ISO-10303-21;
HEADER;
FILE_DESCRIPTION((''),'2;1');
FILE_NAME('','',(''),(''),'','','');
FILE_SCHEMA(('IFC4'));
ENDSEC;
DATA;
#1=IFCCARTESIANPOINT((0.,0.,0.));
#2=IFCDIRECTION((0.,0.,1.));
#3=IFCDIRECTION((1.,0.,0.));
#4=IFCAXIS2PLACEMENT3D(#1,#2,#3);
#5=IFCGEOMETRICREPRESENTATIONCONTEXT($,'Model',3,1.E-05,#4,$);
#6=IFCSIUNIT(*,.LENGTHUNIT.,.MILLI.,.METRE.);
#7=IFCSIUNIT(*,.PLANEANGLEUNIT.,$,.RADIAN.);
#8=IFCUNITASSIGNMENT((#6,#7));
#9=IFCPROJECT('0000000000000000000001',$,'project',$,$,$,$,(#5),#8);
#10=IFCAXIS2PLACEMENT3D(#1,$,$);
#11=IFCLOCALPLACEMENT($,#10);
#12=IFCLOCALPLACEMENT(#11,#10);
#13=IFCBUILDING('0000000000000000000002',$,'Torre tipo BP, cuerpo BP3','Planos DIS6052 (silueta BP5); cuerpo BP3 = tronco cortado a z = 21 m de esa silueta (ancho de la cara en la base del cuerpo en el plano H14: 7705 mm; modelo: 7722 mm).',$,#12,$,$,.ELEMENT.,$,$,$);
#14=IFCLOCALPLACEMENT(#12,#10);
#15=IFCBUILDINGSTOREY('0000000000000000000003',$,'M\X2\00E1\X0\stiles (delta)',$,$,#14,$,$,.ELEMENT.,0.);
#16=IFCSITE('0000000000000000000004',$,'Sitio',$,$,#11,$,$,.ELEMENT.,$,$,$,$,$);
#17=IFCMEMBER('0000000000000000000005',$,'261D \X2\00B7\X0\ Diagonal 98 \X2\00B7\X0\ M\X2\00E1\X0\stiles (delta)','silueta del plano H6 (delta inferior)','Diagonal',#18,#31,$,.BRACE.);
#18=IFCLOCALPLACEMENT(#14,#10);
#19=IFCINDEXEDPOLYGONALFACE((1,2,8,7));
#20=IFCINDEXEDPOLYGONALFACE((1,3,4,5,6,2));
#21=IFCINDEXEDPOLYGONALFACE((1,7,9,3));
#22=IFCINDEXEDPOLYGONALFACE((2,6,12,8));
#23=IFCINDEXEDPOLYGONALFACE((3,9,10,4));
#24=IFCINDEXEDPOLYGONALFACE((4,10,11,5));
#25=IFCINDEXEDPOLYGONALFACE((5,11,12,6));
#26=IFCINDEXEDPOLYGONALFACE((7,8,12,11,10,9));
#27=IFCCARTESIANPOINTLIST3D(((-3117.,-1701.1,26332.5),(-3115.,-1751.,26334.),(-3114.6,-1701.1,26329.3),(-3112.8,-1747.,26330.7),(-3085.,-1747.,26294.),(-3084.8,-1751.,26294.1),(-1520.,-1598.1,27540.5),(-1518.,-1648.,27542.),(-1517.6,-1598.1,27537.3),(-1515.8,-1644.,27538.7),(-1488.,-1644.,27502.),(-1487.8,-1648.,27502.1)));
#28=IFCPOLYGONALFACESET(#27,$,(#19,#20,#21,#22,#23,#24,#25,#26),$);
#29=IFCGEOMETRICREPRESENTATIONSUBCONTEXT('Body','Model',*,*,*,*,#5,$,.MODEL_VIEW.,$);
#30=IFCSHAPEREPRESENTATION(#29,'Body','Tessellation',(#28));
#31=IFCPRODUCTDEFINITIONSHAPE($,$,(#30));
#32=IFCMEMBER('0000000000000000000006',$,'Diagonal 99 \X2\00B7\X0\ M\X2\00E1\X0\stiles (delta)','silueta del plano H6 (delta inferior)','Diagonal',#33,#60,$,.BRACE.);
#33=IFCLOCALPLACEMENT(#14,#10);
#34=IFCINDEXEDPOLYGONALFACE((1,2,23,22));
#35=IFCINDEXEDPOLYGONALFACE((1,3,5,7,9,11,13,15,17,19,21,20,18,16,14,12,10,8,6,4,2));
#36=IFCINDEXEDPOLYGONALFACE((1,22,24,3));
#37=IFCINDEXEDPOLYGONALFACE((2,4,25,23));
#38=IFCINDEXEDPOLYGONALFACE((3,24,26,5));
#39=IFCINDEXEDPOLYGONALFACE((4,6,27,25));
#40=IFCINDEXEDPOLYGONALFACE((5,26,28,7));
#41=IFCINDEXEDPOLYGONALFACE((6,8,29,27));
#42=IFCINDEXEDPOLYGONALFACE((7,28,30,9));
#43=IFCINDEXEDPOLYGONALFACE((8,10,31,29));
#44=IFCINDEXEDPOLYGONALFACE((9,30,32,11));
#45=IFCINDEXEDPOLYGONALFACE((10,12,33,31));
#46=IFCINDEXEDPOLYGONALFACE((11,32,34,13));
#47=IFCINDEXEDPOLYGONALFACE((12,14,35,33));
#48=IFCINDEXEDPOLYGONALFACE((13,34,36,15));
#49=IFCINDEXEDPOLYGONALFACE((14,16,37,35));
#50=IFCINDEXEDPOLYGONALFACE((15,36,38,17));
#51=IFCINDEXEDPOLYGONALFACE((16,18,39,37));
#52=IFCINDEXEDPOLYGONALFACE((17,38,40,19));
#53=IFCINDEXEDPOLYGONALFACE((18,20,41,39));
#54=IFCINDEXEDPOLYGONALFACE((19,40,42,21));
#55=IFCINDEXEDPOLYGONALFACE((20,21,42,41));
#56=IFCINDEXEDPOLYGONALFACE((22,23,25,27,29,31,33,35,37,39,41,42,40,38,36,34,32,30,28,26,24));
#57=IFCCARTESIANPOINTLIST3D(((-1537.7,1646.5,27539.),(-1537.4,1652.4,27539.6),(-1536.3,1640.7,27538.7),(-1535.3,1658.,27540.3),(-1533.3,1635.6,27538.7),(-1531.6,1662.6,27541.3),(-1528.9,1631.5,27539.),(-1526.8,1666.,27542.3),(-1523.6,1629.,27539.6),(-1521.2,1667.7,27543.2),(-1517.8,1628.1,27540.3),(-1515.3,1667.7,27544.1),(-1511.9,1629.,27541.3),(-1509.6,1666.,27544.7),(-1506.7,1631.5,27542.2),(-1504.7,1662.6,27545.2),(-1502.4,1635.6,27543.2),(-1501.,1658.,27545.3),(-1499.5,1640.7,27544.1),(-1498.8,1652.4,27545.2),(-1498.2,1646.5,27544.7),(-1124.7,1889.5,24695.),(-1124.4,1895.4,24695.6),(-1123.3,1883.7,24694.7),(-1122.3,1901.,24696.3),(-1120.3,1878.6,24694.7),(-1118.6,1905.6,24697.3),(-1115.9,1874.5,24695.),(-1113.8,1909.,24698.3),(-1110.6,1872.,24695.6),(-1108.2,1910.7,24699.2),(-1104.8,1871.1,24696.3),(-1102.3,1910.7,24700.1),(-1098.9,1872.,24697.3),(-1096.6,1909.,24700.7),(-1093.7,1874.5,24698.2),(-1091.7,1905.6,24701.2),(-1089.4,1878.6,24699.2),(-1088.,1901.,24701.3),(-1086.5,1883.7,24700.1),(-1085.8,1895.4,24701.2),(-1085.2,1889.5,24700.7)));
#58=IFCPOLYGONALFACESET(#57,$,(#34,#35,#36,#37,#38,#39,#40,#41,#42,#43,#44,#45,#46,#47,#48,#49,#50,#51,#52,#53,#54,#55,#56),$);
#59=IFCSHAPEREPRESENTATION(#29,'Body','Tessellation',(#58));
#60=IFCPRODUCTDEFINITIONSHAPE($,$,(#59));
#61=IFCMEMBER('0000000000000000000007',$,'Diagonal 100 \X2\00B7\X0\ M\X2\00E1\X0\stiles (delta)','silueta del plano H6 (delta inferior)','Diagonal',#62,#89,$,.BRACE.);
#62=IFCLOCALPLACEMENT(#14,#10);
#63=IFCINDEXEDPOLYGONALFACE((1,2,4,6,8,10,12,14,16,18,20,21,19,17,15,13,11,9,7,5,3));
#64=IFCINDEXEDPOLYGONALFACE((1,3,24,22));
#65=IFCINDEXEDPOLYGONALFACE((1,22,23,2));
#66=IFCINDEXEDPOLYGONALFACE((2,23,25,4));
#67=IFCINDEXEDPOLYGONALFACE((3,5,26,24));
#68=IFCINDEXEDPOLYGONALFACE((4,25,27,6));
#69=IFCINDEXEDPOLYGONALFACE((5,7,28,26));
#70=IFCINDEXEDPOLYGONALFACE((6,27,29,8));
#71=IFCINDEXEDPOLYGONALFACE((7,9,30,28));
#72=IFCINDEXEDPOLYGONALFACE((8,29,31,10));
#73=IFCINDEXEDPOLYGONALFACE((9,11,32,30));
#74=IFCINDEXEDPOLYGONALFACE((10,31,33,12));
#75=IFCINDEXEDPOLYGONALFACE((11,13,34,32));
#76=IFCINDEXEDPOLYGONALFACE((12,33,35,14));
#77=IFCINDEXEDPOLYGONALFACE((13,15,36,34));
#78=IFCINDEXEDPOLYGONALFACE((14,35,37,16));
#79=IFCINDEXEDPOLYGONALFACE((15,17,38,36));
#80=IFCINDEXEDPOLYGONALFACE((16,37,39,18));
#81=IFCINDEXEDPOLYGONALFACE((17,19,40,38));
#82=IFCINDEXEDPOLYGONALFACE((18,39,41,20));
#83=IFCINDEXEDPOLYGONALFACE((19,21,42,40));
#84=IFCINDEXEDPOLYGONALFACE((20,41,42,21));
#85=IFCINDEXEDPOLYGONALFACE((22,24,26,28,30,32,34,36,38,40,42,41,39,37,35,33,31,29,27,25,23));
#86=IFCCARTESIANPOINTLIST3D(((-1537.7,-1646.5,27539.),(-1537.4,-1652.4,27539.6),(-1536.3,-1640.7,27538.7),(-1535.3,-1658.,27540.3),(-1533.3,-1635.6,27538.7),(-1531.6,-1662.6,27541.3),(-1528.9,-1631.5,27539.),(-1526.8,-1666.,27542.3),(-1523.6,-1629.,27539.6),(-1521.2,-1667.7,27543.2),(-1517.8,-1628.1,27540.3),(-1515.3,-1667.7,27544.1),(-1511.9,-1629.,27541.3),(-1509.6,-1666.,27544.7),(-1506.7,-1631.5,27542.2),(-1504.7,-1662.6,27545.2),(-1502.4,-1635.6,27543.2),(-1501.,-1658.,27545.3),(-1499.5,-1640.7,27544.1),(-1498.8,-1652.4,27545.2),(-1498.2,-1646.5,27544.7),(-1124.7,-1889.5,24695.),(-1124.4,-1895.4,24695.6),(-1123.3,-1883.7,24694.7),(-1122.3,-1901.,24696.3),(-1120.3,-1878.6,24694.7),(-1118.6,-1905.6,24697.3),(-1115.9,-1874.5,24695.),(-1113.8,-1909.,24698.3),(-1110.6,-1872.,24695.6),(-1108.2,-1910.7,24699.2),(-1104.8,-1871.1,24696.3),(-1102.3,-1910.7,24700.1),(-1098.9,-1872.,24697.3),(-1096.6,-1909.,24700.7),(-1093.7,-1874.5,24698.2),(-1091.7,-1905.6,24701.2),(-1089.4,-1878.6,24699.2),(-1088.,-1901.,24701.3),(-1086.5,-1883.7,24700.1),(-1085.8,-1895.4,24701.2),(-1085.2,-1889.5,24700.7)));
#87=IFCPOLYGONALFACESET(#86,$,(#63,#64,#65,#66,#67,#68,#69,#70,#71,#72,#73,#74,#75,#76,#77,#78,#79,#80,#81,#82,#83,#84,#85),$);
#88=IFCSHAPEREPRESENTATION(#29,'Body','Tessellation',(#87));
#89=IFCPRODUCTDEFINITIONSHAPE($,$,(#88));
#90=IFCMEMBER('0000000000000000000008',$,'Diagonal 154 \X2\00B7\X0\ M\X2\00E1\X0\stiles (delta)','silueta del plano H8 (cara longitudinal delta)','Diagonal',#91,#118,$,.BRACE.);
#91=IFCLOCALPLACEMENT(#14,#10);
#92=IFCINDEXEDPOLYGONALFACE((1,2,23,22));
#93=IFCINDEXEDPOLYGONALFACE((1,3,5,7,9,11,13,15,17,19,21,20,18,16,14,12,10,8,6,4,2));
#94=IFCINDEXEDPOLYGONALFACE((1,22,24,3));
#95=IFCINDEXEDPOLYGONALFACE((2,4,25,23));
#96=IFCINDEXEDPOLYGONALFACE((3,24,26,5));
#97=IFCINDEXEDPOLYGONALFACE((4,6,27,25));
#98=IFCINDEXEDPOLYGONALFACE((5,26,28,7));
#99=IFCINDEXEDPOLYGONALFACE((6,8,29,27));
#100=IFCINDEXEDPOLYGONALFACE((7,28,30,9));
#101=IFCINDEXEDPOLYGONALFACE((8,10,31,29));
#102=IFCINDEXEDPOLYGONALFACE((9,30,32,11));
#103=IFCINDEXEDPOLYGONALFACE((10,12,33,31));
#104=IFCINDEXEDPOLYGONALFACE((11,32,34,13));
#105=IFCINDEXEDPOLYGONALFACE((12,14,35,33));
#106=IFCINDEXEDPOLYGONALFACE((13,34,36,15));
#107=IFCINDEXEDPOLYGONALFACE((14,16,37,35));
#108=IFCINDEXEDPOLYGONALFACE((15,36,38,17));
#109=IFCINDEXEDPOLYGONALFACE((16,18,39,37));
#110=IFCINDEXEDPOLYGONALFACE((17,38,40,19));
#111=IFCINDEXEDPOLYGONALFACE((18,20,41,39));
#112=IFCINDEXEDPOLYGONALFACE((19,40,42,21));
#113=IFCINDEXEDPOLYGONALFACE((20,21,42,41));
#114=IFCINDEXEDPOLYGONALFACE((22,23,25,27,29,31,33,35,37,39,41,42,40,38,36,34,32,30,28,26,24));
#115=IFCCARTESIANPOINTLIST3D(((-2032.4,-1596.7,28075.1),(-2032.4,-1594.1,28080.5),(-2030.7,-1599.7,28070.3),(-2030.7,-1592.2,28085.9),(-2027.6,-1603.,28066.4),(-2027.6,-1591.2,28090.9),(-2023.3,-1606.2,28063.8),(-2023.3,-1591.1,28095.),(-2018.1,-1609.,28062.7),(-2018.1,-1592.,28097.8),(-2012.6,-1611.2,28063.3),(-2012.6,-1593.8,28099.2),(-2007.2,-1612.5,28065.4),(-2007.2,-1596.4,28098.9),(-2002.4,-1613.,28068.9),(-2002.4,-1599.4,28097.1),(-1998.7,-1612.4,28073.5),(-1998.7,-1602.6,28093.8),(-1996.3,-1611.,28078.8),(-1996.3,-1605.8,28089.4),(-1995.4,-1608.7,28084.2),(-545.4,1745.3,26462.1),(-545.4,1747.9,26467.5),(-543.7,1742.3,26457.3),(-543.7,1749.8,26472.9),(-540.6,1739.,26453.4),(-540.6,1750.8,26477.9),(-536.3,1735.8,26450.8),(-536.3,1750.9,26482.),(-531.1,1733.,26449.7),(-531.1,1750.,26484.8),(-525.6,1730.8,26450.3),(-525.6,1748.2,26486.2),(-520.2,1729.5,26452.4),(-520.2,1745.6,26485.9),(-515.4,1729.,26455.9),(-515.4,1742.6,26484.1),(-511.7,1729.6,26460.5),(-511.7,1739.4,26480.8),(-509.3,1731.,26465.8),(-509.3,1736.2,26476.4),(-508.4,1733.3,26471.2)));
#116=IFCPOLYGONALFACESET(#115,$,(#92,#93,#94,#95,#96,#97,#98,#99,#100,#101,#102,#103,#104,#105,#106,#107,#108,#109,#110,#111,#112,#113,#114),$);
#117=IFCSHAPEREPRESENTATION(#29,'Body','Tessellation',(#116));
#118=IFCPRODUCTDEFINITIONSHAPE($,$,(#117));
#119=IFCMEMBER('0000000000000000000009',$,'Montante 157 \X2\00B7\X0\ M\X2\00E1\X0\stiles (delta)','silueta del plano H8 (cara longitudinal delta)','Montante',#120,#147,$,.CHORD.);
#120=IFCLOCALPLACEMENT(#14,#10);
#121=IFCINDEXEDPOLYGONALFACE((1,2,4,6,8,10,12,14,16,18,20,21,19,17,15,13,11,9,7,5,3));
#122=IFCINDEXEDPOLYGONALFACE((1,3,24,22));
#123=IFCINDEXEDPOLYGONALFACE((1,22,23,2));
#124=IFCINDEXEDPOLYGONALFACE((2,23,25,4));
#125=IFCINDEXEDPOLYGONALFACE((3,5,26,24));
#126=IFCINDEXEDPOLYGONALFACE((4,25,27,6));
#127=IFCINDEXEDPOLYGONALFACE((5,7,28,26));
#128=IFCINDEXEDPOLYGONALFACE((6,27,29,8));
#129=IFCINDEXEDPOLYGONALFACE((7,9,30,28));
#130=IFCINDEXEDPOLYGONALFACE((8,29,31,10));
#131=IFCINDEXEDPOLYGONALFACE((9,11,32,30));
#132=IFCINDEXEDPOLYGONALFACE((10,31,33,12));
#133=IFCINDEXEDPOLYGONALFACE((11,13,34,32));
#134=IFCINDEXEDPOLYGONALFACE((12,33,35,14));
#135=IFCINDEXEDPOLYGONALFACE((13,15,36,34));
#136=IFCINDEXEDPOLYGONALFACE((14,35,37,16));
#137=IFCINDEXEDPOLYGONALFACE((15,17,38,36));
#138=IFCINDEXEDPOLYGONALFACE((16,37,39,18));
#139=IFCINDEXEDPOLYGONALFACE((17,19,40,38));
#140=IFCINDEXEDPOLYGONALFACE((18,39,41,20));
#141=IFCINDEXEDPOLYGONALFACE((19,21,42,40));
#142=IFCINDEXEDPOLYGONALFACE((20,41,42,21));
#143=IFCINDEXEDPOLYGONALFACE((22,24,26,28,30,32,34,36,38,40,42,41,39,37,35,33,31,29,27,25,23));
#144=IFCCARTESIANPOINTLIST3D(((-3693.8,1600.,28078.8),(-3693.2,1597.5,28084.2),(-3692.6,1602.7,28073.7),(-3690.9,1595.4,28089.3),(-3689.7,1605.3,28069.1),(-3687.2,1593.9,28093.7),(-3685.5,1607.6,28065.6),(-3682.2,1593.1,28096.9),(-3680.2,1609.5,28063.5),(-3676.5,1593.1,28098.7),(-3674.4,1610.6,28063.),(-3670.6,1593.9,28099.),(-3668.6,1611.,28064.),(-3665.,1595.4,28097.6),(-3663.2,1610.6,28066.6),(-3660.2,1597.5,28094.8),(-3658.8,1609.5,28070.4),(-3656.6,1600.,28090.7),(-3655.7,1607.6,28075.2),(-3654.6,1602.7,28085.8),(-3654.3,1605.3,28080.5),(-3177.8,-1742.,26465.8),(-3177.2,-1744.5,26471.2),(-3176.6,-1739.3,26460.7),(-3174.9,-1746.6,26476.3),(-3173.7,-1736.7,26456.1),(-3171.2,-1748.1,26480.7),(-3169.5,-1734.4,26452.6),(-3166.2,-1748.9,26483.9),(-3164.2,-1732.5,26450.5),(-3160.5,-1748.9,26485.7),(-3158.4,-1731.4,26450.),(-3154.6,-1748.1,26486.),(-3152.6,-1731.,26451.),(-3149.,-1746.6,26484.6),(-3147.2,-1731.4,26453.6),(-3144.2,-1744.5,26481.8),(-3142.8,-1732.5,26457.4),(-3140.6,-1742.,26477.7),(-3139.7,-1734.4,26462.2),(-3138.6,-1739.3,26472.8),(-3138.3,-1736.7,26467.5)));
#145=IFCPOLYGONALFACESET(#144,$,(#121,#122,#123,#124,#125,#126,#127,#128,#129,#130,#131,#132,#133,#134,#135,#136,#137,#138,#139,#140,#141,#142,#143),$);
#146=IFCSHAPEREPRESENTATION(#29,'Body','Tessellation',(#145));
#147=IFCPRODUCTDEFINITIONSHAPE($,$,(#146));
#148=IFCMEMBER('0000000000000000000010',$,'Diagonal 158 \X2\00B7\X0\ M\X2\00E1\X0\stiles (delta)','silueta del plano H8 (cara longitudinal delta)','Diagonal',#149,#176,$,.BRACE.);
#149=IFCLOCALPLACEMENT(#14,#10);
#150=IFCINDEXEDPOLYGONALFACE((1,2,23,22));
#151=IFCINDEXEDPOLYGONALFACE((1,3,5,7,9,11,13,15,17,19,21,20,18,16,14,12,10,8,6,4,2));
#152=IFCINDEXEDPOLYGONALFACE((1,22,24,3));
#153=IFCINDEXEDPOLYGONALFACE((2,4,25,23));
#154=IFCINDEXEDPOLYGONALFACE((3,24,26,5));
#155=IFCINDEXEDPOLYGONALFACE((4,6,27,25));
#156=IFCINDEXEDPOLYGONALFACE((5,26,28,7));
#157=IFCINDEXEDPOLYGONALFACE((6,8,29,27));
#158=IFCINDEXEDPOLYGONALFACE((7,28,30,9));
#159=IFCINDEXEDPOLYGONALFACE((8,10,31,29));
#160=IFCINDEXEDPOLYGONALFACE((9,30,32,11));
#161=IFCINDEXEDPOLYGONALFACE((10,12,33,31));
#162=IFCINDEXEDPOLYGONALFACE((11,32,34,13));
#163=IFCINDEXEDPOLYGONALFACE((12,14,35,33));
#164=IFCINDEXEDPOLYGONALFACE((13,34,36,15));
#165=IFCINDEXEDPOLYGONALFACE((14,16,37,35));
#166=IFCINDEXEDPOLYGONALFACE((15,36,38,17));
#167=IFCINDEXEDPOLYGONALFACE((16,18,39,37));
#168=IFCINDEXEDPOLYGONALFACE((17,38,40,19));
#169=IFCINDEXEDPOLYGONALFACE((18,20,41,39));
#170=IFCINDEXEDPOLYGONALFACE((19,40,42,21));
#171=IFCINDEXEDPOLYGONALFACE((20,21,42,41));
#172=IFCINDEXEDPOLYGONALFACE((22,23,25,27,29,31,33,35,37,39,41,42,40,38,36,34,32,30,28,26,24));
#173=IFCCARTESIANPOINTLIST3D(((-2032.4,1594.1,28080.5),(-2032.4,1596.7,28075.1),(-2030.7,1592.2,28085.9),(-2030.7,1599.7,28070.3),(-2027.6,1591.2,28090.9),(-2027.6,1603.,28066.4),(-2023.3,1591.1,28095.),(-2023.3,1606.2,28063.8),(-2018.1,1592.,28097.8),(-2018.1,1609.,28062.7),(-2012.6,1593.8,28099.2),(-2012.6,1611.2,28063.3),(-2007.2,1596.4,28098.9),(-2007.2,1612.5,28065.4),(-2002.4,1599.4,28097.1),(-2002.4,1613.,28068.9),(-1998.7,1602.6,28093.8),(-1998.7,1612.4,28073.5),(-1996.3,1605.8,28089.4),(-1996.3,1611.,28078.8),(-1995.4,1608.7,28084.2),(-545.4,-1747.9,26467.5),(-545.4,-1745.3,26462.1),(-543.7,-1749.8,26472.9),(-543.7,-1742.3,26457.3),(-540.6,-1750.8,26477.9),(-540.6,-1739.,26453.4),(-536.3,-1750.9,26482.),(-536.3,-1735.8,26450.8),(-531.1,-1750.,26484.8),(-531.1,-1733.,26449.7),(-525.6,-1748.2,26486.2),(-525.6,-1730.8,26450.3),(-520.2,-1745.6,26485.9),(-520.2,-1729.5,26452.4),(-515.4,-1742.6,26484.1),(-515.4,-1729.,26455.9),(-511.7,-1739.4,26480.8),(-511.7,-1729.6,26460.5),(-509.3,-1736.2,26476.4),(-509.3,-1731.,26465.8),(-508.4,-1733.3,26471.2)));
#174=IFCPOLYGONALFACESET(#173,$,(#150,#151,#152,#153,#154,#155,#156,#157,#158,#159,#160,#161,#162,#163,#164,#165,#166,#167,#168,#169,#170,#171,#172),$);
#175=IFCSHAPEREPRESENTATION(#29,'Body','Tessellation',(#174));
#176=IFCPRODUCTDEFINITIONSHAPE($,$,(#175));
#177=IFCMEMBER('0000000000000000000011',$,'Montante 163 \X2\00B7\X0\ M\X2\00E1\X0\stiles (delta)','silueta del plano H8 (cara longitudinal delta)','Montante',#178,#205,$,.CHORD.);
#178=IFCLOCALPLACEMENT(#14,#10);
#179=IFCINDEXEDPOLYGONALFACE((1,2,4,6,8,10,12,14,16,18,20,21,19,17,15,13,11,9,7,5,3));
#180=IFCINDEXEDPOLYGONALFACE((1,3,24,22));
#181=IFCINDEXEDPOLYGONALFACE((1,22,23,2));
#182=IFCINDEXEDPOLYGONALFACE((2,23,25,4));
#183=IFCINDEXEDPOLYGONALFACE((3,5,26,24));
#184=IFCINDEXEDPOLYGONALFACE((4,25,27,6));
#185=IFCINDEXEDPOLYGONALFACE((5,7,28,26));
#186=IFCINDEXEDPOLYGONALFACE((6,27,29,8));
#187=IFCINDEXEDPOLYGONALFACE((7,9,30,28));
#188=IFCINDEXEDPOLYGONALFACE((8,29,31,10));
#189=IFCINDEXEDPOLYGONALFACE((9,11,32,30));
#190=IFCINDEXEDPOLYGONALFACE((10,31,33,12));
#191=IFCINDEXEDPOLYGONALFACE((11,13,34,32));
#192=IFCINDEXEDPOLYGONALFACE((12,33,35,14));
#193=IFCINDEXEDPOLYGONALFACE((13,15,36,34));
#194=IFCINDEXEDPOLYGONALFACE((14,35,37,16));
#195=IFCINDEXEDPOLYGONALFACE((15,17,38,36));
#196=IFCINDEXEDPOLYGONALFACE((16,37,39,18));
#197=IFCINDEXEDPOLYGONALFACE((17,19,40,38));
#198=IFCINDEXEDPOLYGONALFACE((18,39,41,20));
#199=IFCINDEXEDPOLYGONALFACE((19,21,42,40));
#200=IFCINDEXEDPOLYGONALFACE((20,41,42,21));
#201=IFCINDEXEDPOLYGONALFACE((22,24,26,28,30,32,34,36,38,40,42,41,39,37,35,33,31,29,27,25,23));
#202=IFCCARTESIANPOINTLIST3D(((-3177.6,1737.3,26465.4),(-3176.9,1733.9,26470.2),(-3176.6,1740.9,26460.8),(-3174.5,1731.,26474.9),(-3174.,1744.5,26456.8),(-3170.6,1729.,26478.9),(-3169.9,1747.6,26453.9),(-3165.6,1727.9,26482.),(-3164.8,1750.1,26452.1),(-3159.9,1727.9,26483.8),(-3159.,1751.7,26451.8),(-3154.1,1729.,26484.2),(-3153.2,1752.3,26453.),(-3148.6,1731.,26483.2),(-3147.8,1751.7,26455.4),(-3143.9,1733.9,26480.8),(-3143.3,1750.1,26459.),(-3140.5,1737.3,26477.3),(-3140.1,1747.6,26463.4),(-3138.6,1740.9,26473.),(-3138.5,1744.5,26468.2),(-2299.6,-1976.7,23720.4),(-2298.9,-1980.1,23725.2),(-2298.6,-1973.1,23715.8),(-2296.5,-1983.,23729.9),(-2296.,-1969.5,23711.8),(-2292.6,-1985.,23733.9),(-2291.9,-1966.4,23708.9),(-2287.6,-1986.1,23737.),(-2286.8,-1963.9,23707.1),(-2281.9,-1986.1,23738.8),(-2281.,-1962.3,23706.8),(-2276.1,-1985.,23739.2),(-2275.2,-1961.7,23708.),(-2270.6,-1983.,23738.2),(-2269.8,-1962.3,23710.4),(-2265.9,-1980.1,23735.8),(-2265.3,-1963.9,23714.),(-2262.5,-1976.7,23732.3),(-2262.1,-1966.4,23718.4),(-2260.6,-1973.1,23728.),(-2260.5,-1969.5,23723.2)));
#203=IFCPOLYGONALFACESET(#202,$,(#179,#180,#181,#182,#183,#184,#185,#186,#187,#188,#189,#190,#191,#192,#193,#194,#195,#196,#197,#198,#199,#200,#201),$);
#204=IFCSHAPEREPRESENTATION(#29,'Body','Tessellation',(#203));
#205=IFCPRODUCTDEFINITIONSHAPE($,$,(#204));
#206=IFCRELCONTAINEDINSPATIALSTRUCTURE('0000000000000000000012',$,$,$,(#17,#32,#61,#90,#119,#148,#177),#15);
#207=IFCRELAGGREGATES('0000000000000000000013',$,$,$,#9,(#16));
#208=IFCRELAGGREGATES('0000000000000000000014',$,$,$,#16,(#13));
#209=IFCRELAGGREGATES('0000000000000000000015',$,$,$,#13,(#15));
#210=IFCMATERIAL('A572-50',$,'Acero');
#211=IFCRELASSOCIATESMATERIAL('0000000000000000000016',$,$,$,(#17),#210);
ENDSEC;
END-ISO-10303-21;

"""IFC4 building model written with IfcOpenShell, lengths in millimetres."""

from ifc_helpers import new_model, si_unit, frame, frame_2d, origin, origin_with_axes, place, context, subcontext, project, spatial, circle, l_section, extrude, material, element, save


model = new_model("IFC4")

# Units and contexts
model_context = context("Model", 3, precision=1e-05, world=origin_with_axes())
body_context = subcontext(model_context, "Body", "Model", "MODEL_VIEW")
ifc_project = project(units=[si_unit("LENGTHUNIT", "METRE", prefix="MILLI"), si_unit("PLANEANGLEUNIT", "RADIAN")], contexts=[model_context])

# Site, building, storey
site_placement = place(None, origin())
site = spatial("IfcSite", under=ifc_project, at=site_placement, Name="Sitio", CompositionType="ELEMENT")
building_placement = place(site_placement, origin())
building = spatial("IfcBuilding", under=site, at=building_placement, Name="Torre tipo BP, cuerpo BP3", Description="Planos DIS6052 (silueta BP5); cuerpo BP3 = tronco cortado a z = 21 m de esa silueta (ancho de la cara en la base del cuerpo en el plano H14: 7705 mm; modelo: 7722 mm).", CompositionType="ELEMENT")
storey_placement = place(building_placement, origin())
storey = spatial("IfcBuildingStorey", under=building, at=storey_placement, Name="Mástiles (delta)", CompositionType="ELEMENT", Elevation=0.0)

# Members
ifc_material = material(Name="A572-50", Category="Acero")
for number, where, z_axis, x_axis, name in (
    (1, (-1518.0, -1648.0, 27542.0), (-0.796483, -0.05137, -0.602475), (-0.040969, 0.99868, -0.03099), "261D · Diagonal 98 · Mástiles (delta)"),
):
    element("IfcMember", number, at=place(storey_placement, frame(where, z_axis=z_axis, x_axis=x_axis)), inside=storey, material=ifc_material, Name=name, Description="silueta del plano H6 (delta inferior)", ObjectType="Diagonal", PredefinedType="BRACE", context=body_context, shape_type="SweptSolid", body=[
        extrude(l_section(Depth=50.0, Width=50.0, Thickness=4.0, at=frame_2d((25.0, 25.0))), None, (0.0, 0.0, 1.0), 2005.1),
    ])
for number, where, z_axis, x_axis, name in (
    (2, (-1518.0, 1648.0, 27542.0), (0.1432, 0.084255, -0.986101), (0.012108, -0.996444, -0.083381), "Diagonal 99 · Mástiles (delta)"),
    (3, (-1518.0, -1648.0, 27542.0), (0.1432, -0.084255, -0.986101), (0.012108, 0.996444, -0.083381), "Diagonal 100 · Mástiles (delta)"),
):
    element("IfcMember", number, at=place(storey_placement, frame(where, z_axis=z_axis, x_axis=x_axis)), inside=storey, Name=name, Description="silueta del plano H6 (delta inferior)", ObjectType="Diagonal", PredefinedType="BRACE", context=body_context, shape_type="SweptSolid", body=[
        extrude(circle(Radius=20.0), None, (0.0, 0.0, 1.0), 2884.1),
    ])
member_1_placement = place(storey_placement, frame((-2014.0, -1602.0, 28081.0), z_axis=(0.37196, 0.835973, -0.403478), x_axis=(0.928249, -0.334984, 0.161679)))
element("IfcMember", 4, at=member_1_placement, inside=storey, Name="Diagonal 154 · Mástiles (delta)", Description="silueta del plano H8 (cara longitudinal delta)", ObjectType="Diagonal", PredefinedType="BRACE", context=body_context, shape_type="SweptSolid", body=[
    extrude(circle(Radius=20.0), None, (0.0, 0.0, 1.0), 3997.7),
])
member_2_placement = place(storey_placement, frame((-3674.0, 1602.0, 28081.0), z_axis=(0.137725, -0.892009, -0.430524), x_axis=(0.271786, 0.452017, -0.849596)))
element("IfcMember", 5, at=member_2_placement, inside=storey, Name="Montante 157 · Mástiles (delta)", Description="silueta del plano H8 (cara longitudinal delta)", ObjectType="Montante", PredefinedType="CHORD", context=body_context, shape_type="SweptSolid", body=[
    extrude(circle(Radius=20.0), None, (0.0, 0.0, 1.0), 3746.6),
])
member_3_placement = place(storey_placement, frame((-2014.0, 1602.0, 28081.0), z_axis=(0.37196, -0.835973, -0.403478), x_axis=(0.928249, 0.334984, 0.161679)))
element("IfcMember", 6, at=member_3_placement, inside=storey, Name="Diagonal 158 · Mástiles (delta)", Description="silueta del plano H8 (cara longitudinal delta)", ObjectType="Diagonal", PredefinedType="BRACE", context=body_context, shape_type="SweptSolid", body=[
    extrude(circle(Radius=20.0), None, (0.0, 0.0, 1.0), 3997.7),
])
for number, where, z_axis, x_axis, name in (
    (7, (-3158.0, 1740.0, 26468.0), (0.186767, -0.790039, -0.583914), (0.240685, 0.613056, -0.752484), "Montante 163 · Mástiles (delta)"),
):
    element("IfcMember", number, at=place(storey_placement, frame(where, z_axis=z_axis, x_axis=x_axis)), inside=storey, Name=name, Description="silueta del plano H8 (cara longitudinal delta)", ObjectType="Montante", PredefinedType="CHORD", context=body_context, shape_type="SweptSolid", body=[
        extrude(circle(Radius=20.0), None, (0.0, 0.0, 1.0), 4701.0),
    ])

save(model, "model.ifc")
